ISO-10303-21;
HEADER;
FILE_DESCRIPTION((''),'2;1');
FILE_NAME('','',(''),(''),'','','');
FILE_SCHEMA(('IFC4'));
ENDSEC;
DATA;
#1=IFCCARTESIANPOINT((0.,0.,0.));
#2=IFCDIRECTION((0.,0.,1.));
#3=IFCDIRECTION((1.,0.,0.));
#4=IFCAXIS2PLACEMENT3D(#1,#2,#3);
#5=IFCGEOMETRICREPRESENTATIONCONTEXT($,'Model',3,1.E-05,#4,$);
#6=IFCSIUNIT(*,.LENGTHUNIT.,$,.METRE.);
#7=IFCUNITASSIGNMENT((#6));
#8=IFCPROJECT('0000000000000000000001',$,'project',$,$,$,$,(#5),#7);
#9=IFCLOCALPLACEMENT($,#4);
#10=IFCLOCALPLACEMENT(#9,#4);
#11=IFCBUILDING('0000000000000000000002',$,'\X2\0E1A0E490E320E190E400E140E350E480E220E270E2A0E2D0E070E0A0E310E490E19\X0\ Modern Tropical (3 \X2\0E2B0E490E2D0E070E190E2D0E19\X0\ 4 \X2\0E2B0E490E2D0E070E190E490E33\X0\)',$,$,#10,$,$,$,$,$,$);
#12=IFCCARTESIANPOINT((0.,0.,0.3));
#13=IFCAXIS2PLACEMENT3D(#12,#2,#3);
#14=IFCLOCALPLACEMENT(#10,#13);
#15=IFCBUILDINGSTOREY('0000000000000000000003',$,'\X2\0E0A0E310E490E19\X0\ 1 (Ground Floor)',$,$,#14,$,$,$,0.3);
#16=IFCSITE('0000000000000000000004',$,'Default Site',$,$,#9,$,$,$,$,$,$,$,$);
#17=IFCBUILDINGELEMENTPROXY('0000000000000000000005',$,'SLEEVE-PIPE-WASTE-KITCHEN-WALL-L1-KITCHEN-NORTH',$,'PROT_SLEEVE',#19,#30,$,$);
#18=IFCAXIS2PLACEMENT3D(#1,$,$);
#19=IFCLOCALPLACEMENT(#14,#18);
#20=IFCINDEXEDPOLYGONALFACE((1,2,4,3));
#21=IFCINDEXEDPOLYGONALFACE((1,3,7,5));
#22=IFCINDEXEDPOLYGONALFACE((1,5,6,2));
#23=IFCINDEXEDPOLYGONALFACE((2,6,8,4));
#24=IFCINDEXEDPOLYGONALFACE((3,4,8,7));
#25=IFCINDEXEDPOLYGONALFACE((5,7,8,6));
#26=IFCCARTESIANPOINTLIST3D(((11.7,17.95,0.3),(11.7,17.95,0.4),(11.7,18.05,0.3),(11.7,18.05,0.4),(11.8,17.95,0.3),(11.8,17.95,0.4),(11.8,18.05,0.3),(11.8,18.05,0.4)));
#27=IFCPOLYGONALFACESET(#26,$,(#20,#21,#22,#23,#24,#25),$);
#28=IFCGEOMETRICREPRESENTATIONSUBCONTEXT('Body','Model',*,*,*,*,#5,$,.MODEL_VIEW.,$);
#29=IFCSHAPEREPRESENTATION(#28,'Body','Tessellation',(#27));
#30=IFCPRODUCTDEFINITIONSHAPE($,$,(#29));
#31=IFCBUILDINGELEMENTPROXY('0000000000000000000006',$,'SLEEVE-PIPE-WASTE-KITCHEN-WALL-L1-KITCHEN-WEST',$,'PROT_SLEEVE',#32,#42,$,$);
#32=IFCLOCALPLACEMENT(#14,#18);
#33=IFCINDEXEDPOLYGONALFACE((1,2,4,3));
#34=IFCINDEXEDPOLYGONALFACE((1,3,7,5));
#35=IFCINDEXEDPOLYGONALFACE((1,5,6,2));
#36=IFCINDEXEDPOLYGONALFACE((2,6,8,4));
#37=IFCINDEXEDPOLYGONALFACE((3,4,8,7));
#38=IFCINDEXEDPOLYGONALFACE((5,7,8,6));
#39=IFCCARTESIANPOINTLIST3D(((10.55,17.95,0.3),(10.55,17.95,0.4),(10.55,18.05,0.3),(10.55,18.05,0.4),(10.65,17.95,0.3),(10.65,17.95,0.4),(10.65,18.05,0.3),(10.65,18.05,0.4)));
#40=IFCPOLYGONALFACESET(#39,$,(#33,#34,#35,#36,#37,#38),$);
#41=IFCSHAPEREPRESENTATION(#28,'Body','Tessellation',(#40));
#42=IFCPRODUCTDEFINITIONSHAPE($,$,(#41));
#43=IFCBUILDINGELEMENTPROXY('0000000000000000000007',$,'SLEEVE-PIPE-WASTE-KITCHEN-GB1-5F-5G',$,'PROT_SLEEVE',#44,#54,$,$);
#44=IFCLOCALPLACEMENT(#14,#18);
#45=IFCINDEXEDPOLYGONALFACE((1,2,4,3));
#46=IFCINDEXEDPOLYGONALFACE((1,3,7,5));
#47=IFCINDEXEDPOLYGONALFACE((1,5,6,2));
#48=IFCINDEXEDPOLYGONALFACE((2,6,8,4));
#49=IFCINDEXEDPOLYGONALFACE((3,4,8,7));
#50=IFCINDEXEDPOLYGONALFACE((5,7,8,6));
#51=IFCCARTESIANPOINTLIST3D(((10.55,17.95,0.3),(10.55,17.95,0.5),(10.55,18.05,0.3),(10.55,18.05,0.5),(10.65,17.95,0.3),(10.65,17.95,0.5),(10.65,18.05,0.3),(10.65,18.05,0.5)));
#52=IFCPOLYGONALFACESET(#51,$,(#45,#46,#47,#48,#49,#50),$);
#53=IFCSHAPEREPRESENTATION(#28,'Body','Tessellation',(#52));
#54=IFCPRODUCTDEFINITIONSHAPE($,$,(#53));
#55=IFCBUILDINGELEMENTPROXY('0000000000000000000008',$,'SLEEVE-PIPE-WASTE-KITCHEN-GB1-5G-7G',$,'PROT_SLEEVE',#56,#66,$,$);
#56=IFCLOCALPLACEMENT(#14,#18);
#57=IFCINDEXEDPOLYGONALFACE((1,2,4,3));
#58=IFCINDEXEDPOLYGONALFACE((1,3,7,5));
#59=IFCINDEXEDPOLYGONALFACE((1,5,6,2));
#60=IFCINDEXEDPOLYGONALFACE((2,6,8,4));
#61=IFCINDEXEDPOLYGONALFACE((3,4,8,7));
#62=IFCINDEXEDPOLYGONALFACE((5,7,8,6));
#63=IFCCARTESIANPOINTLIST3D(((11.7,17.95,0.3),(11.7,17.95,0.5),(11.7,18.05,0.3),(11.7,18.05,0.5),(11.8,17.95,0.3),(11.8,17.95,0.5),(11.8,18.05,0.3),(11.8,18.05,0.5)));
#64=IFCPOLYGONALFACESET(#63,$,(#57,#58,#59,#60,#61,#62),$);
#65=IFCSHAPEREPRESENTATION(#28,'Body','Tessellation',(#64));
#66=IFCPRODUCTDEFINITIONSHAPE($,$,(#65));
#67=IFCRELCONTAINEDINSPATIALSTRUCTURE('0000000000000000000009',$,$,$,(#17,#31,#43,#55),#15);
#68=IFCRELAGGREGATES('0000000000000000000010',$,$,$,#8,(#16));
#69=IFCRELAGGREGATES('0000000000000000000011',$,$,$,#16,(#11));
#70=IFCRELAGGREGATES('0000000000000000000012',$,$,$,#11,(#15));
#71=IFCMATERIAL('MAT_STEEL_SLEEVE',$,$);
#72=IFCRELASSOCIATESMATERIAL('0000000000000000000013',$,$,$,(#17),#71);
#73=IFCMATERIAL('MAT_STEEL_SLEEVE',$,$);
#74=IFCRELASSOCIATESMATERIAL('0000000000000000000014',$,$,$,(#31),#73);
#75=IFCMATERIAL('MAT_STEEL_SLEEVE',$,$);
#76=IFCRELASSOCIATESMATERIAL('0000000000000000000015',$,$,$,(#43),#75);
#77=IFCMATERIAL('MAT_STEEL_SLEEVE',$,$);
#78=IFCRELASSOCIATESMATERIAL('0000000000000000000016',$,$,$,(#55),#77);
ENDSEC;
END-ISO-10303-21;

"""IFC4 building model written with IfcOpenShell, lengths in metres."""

from ifc_helpers import new_model, si_unit, frame, origin_with_axes, origin_2d, place, context, subcontext, project, spatial, rectangle, extrude, material, element, save


model = new_model("IFC4")

# Units and contexts
model_context = context("Model", 3, precision=1e-05, world=origin_with_axes())
body_context = subcontext(model_context, "Body", "Model", "MODEL_VIEW")
ifc_project = project(units=[si_unit("LENGTHUNIT", "METRE")], contexts=[model_context])

# Site, building, storey
site_placement = place(None, origin_with_axes())
site = spatial("IfcSite", under=ifc_project, at=site_placement, Name="Default Site")
building_placement = place(site_placement, origin_with_axes())
building = spatial("IfcBuilding", under=site, at=building_placement, Name="บ้านเดี่ยวสองชั้น Modern Tropical (3 ห้องนอน 4 ห้องน้ำ)")
storey_placement = place(building_placement, frame((0.0, 0.0, 0.3), z_axis=(0.0, 0.0, 1.0), x_axis=(1.0, 0.0, 0.0)))
storey = spatial("IfcBuildingStorey", under=building, at=storey_placement, Name="ชั้น 1 (Ground Floor)", Elevation=0.3)

# Building element proxies
ifc_material_1 = material(Name="MAT_STEEL_SLEEVE")
proxy_1_placement = place(storey_placement, frame((11.75, 18.0, 0.3), z_axis=(0.0, 0.0, 1.0), x_axis=(1.0, 0.0, 0.0)))
element("IfcBuildingElementProxy", 1, at=proxy_1_placement, inside=storey, material=ifc_material_1, Name="SLEEVE-PIPE-WASTE-KITCHEN-WALL-L1-KITCHEN-NORTH", ObjectType="PROT_SLEEVE", context=body_context, shape_type="SweptSolid", body=[
    extrude(rectangle(XDim=0.1, YDim=0.1, at=origin_2d()), origin_with_axes(), (0.0, 0.0, 1.0), 0.1),
])
ifc_material_2 = material(Name="MAT_STEEL_SLEEVE")
proxy_2_placement = place(storey_placement, frame((10.6, 18.0, 0.3), z_axis=(0.0, 0.0, 1.0), x_axis=(1.0, 0.0, 0.0)))
element("IfcBuildingElementProxy", 2, at=proxy_2_placement, inside=storey, material=ifc_material_2, Name="SLEEVE-PIPE-WASTE-KITCHEN-WALL-L1-KITCHEN-WEST", ObjectType="PROT_SLEEVE", context=body_context, shape_type="SweptSolid", body=[
    extrude(rectangle(XDim=0.1, YDim=0.1, at=origin_2d()), origin_with_axes(), (0.0, 0.0, 1.0), 0.1),
])
ifc_material_3 = material(Name="MAT_STEEL_SLEEVE")
proxy_3_placement = place(storey_placement, frame((10.6, 18.0, 0.3), z_axis=(0.0, 0.0, 1.0), x_axis=(1.0, 0.0, 0.0)))
element("IfcBuildingElementProxy", 3, at=proxy_3_placement, inside=storey, material=ifc_material_3, Name="SLEEVE-PIPE-WASTE-KITCHEN-GB1-5F-5G", ObjectType="PROT_SLEEVE", context=body_context, shape_type="SweptSolid", body=[
    extrude(rectangle(XDim=0.1, YDim=0.1, at=origin_2d()), origin_with_axes(), (0.0, 0.0, 1.0), 0.2),
])
ifc_material_4 = material(Name="MAT_STEEL_SLEEVE")
proxy_4_placement = place(storey_placement, frame((11.75, 18.0, 0.3), z_axis=(0.0, 0.0, 1.0), x_axis=(1.0, 0.0, 0.0)))
element("IfcBuildingElementProxy", 4, at=proxy_4_placement, inside=storey, material=ifc_material_4, Name="SLEEVE-PIPE-WASTE-KITCHEN-GB1-5G-7G", ObjectType="PROT_SLEEVE", context=body_context, shape_type="SweptSolid", body=[
    extrude(rectangle(XDim=0.1, YDim=0.1, at=origin_2d()), origin_with_axes(), (0.0, 0.0, 1.0), 0.2),
])

save(model, "model.ifc")
